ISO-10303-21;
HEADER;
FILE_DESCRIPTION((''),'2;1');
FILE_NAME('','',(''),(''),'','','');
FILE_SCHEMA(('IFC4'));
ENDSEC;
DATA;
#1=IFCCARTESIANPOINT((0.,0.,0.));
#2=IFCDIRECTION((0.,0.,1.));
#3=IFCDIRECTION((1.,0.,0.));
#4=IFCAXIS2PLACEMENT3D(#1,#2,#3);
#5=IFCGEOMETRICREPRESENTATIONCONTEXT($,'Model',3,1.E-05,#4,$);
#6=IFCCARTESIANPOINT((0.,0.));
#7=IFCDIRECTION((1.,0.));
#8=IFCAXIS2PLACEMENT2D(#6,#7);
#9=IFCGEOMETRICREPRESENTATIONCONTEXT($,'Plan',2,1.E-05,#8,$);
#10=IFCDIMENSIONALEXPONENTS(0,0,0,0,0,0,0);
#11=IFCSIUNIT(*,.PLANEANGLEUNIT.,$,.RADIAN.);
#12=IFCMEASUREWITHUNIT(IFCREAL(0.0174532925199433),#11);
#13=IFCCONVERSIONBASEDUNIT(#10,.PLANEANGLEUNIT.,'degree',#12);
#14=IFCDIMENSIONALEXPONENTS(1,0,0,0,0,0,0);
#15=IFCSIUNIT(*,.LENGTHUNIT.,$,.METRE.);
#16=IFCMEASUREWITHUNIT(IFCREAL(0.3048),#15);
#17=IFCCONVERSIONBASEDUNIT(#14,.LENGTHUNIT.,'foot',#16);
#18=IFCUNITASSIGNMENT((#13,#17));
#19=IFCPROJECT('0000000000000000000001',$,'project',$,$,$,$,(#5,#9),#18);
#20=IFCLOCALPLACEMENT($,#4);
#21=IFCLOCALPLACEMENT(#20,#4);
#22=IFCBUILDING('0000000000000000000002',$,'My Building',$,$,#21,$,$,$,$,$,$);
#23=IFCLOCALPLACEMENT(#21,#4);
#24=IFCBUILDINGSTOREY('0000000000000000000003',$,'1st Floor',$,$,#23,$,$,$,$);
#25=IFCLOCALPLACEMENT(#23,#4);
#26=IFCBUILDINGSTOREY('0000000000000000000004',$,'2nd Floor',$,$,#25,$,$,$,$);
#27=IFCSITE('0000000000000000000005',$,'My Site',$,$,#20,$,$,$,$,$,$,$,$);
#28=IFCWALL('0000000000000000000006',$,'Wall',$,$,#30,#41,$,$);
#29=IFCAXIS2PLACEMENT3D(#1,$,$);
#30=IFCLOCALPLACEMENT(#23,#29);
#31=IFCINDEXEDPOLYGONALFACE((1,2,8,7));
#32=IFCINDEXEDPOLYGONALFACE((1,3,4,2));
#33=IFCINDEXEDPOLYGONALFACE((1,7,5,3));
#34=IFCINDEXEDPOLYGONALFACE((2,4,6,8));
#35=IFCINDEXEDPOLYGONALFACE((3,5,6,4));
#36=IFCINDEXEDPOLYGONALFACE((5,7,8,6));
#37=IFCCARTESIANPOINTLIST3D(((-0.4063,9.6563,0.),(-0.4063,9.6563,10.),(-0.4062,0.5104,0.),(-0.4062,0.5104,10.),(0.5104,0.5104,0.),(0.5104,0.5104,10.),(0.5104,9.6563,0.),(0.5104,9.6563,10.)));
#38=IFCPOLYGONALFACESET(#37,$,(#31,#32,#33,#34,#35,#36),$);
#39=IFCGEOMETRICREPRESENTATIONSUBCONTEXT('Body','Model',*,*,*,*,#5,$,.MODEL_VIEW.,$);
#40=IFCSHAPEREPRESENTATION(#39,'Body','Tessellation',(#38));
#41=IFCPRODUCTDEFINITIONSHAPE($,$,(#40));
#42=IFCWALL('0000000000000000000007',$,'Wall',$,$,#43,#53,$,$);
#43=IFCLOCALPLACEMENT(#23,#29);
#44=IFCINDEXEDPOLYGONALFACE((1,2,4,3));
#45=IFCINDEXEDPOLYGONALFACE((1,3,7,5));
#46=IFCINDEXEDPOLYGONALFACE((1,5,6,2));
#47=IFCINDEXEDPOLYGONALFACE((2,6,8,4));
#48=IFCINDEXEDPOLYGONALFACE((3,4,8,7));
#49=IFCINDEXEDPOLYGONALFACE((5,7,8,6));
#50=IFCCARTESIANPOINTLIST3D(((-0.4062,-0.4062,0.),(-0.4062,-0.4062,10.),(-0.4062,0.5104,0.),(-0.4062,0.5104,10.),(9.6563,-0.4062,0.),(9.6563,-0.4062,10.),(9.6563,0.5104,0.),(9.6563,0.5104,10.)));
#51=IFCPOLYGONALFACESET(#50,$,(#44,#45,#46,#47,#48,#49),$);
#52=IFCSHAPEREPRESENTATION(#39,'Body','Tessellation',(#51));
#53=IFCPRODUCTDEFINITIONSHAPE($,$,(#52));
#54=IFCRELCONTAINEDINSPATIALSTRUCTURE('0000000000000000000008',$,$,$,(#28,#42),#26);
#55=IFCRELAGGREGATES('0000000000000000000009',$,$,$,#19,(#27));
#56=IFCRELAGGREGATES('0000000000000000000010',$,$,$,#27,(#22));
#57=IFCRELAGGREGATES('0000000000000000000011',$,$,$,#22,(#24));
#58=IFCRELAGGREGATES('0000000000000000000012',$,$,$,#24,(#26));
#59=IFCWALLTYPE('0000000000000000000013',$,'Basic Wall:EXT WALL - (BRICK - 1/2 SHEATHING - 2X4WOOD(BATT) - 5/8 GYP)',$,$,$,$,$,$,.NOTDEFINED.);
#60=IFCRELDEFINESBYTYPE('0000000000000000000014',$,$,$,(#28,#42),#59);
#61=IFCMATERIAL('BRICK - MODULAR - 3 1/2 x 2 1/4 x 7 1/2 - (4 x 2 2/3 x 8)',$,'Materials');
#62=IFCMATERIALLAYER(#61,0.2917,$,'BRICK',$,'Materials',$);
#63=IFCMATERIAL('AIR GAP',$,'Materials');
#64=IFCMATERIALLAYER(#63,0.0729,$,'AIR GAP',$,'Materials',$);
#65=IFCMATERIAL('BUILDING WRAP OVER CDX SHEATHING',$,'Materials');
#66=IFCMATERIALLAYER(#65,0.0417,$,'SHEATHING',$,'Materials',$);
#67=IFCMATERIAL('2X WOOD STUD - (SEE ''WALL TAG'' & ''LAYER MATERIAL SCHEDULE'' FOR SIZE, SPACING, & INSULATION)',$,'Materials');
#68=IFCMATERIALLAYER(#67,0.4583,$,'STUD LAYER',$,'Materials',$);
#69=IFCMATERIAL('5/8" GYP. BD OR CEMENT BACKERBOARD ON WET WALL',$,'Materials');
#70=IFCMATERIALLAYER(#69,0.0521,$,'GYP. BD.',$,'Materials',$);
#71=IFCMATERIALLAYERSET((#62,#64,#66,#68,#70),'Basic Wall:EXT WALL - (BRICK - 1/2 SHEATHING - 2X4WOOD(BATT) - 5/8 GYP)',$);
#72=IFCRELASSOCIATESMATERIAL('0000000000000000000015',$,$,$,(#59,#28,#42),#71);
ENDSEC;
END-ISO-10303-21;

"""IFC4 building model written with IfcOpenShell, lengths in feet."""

from ifc_helpers import new_model, entity, si_unit, converted_unit, frame, origin_with_axes, origin_2d_with_axis, place, context, subcontext, project, spatial, indexed_curve, outline, extrude, material, layer, layer_set, layer_usage, type_object, element, save


model = new_model("IFC4")

# Units and contexts
model_context = context("Model", 3, precision=1e-05, world=origin_with_axes())
plan_context = context("Plan", 2, precision=1e-05, world=origin_2d_with_axis())
body_context = subcontext(model_context, "Body", "Model", "MODEL_VIEW")
ifc_project = project(units=[converted_unit("PLANEANGLEUNIT", "degree", entity("IfcReal", 0.0174532925199433), si_unit("PLANEANGLEUNIT", "RADIAN"), dimensions=[0, 0, 0, 0, 0, 0, 0]), converted_unit("LENGTHUNIT", "foot", entity("IfcReal", 0.3048), si_unit("LENGTHUNIT", "METRE"), dimensions=[1, 0, 0, 0, 0, 0, 0])], contexts=[model_context, plan_context])

# Site, building, storeys
site_placement = place(None, origin_with_axes())
site = spatial("IfcSite", under=ifc_project, at=site_placement, Name="My Site")
building_placement = place(site_placement, origin_with_axes())
building = spatial("IfcBuilding", under=site, at=building_placement, Name="My Building")
storey_1_placement = place(building_placement, origin_with_axes())
storey_1 = spatial("IfcBuildingStorey", under=building, at=storey_1_placement, Name="1st Floor")
storey_2_placement = place(storey_1_placement, origin_with_axes())
storey_2 = spatial("IfcBuildingStorey", under=storey_1, at=storey_2_placement, Name="2nd Floor")

# Walls
ifc_material_1 = material(Name="BRICK - MODULAR - 3 1/2 x 2 1/4 x 7 1/2 - (4 x 2 2/3 x 8)", Category="Materials")
ifc_layer_1 = layer(ifc_material_1, 0.2917, Name="BRICK", Category="Materials")
ifc_material_2 = material(Name="AIR GAP", Category="Materials")
ifc_layer_2 = layer(ifc_material_2, 0.0729, Name="AIR GAP", Category="Materials")
ifc_material_3 = material(Name="BUILDING WRAP OVER CDX SHEATHING", Category="Materials")
ifc_layer_3 = layer(ifc_material_3, 0.0417, Name="SHEATHING", Category="Materials")
ifc_material_4 = material(Name="2X WOOD STUD - (SEE 'WALL TAG' & 'LAYER MATERIAL SCHEDULE' FOR SIZE, SPACING, & INSULATION)", Category="Materials")
ifc_layer_4 = layer(ifc_material_4, 0.4583, Name="STUD LAYER", Category="Materials")
ifc_material_5 = material(Name="5/8\" GYP. BD OR CEMENT BACKERBOARD ON WET WALL", Category="Materials")
ifc_layer_5 = layer(ifc_material_5, 0.0521, Name="GYP. BD.", Category="Materials")
ifc_layer_set = layer_set([ifc_layer_1, ifc_layer_2, ifc_layer_3, ifc_layer_4, ifc_layer_5], Name="Basic Wall:EXT WALL - (BRICK - 1/2 SHEATHING - 2X4WOOD(BATT) - 5/8 GYP)")
ifc_layer_usage_1 = layer_usage(ifc_layer_set, "AXIS2", "POSITIVE", 0.0)
wall_type = type_object("IfcWallType", Name="Basic Wall:EXT WALL - (BRICK - 1/2 SHEATHING - 2X4WOOD(BATT) - 5/8 GYP)", PredefinedType="NOTDEFINED", material=ifc_layer_set)
wall_1_placement = place(storey_2_placement, frame((-0.4063, 9.6563, 0.0), z_axis=(0.0, 0.0, 1.0), x_axis=(0.0, -1.0, 0.0)))
element("IfcWall", 1, at=wall_1_placement, inside=storey_2, type_object=wall_type, material=ifc_layer_usage_1, Name="Wall", context=body_context, shape_type="SweptSolid", body=[
    extrude(outline(indexed_curve([(0.0, 0.0), (0.0, 0.9167), (9.1458, 0.9167), (9.1458, 0.0), (0.0, 0.0)], self_intersect=False)), origin_with_axes(), (0.0, 0.0, 1.0), 10.0),
])
ifc_layer_usage_2 = layer_usage(ifc_layer_set, "AXIS2", "POSITIVE", 0.0)
wall_2_placement = place(storey_2_placement, frame((-0.4062, -0.4062, 0.0), z_axis=(0.0, 0.0, 1.0), x_axis=(1.0, 0.0, 0.0)))
element("IfcWall", 2, at=wall_2_placement, inside=storey_2, type_object=wall_type, material=ifc_layer_usage_2, Name="Wall", context=body_context, shape_type="SweptSolid", body=[
    extrude(outline(indexed_curve([(0.0, 0.0), (0.0, 0.9167), (10.0625, 0.9167), (10.0625, 0.0), (0.0, 0.0)], self_intersect=False)), origin_with_axes(), (0.0, 0.0, 1.0), 10.0),
])

save(model, "model.ifc")
